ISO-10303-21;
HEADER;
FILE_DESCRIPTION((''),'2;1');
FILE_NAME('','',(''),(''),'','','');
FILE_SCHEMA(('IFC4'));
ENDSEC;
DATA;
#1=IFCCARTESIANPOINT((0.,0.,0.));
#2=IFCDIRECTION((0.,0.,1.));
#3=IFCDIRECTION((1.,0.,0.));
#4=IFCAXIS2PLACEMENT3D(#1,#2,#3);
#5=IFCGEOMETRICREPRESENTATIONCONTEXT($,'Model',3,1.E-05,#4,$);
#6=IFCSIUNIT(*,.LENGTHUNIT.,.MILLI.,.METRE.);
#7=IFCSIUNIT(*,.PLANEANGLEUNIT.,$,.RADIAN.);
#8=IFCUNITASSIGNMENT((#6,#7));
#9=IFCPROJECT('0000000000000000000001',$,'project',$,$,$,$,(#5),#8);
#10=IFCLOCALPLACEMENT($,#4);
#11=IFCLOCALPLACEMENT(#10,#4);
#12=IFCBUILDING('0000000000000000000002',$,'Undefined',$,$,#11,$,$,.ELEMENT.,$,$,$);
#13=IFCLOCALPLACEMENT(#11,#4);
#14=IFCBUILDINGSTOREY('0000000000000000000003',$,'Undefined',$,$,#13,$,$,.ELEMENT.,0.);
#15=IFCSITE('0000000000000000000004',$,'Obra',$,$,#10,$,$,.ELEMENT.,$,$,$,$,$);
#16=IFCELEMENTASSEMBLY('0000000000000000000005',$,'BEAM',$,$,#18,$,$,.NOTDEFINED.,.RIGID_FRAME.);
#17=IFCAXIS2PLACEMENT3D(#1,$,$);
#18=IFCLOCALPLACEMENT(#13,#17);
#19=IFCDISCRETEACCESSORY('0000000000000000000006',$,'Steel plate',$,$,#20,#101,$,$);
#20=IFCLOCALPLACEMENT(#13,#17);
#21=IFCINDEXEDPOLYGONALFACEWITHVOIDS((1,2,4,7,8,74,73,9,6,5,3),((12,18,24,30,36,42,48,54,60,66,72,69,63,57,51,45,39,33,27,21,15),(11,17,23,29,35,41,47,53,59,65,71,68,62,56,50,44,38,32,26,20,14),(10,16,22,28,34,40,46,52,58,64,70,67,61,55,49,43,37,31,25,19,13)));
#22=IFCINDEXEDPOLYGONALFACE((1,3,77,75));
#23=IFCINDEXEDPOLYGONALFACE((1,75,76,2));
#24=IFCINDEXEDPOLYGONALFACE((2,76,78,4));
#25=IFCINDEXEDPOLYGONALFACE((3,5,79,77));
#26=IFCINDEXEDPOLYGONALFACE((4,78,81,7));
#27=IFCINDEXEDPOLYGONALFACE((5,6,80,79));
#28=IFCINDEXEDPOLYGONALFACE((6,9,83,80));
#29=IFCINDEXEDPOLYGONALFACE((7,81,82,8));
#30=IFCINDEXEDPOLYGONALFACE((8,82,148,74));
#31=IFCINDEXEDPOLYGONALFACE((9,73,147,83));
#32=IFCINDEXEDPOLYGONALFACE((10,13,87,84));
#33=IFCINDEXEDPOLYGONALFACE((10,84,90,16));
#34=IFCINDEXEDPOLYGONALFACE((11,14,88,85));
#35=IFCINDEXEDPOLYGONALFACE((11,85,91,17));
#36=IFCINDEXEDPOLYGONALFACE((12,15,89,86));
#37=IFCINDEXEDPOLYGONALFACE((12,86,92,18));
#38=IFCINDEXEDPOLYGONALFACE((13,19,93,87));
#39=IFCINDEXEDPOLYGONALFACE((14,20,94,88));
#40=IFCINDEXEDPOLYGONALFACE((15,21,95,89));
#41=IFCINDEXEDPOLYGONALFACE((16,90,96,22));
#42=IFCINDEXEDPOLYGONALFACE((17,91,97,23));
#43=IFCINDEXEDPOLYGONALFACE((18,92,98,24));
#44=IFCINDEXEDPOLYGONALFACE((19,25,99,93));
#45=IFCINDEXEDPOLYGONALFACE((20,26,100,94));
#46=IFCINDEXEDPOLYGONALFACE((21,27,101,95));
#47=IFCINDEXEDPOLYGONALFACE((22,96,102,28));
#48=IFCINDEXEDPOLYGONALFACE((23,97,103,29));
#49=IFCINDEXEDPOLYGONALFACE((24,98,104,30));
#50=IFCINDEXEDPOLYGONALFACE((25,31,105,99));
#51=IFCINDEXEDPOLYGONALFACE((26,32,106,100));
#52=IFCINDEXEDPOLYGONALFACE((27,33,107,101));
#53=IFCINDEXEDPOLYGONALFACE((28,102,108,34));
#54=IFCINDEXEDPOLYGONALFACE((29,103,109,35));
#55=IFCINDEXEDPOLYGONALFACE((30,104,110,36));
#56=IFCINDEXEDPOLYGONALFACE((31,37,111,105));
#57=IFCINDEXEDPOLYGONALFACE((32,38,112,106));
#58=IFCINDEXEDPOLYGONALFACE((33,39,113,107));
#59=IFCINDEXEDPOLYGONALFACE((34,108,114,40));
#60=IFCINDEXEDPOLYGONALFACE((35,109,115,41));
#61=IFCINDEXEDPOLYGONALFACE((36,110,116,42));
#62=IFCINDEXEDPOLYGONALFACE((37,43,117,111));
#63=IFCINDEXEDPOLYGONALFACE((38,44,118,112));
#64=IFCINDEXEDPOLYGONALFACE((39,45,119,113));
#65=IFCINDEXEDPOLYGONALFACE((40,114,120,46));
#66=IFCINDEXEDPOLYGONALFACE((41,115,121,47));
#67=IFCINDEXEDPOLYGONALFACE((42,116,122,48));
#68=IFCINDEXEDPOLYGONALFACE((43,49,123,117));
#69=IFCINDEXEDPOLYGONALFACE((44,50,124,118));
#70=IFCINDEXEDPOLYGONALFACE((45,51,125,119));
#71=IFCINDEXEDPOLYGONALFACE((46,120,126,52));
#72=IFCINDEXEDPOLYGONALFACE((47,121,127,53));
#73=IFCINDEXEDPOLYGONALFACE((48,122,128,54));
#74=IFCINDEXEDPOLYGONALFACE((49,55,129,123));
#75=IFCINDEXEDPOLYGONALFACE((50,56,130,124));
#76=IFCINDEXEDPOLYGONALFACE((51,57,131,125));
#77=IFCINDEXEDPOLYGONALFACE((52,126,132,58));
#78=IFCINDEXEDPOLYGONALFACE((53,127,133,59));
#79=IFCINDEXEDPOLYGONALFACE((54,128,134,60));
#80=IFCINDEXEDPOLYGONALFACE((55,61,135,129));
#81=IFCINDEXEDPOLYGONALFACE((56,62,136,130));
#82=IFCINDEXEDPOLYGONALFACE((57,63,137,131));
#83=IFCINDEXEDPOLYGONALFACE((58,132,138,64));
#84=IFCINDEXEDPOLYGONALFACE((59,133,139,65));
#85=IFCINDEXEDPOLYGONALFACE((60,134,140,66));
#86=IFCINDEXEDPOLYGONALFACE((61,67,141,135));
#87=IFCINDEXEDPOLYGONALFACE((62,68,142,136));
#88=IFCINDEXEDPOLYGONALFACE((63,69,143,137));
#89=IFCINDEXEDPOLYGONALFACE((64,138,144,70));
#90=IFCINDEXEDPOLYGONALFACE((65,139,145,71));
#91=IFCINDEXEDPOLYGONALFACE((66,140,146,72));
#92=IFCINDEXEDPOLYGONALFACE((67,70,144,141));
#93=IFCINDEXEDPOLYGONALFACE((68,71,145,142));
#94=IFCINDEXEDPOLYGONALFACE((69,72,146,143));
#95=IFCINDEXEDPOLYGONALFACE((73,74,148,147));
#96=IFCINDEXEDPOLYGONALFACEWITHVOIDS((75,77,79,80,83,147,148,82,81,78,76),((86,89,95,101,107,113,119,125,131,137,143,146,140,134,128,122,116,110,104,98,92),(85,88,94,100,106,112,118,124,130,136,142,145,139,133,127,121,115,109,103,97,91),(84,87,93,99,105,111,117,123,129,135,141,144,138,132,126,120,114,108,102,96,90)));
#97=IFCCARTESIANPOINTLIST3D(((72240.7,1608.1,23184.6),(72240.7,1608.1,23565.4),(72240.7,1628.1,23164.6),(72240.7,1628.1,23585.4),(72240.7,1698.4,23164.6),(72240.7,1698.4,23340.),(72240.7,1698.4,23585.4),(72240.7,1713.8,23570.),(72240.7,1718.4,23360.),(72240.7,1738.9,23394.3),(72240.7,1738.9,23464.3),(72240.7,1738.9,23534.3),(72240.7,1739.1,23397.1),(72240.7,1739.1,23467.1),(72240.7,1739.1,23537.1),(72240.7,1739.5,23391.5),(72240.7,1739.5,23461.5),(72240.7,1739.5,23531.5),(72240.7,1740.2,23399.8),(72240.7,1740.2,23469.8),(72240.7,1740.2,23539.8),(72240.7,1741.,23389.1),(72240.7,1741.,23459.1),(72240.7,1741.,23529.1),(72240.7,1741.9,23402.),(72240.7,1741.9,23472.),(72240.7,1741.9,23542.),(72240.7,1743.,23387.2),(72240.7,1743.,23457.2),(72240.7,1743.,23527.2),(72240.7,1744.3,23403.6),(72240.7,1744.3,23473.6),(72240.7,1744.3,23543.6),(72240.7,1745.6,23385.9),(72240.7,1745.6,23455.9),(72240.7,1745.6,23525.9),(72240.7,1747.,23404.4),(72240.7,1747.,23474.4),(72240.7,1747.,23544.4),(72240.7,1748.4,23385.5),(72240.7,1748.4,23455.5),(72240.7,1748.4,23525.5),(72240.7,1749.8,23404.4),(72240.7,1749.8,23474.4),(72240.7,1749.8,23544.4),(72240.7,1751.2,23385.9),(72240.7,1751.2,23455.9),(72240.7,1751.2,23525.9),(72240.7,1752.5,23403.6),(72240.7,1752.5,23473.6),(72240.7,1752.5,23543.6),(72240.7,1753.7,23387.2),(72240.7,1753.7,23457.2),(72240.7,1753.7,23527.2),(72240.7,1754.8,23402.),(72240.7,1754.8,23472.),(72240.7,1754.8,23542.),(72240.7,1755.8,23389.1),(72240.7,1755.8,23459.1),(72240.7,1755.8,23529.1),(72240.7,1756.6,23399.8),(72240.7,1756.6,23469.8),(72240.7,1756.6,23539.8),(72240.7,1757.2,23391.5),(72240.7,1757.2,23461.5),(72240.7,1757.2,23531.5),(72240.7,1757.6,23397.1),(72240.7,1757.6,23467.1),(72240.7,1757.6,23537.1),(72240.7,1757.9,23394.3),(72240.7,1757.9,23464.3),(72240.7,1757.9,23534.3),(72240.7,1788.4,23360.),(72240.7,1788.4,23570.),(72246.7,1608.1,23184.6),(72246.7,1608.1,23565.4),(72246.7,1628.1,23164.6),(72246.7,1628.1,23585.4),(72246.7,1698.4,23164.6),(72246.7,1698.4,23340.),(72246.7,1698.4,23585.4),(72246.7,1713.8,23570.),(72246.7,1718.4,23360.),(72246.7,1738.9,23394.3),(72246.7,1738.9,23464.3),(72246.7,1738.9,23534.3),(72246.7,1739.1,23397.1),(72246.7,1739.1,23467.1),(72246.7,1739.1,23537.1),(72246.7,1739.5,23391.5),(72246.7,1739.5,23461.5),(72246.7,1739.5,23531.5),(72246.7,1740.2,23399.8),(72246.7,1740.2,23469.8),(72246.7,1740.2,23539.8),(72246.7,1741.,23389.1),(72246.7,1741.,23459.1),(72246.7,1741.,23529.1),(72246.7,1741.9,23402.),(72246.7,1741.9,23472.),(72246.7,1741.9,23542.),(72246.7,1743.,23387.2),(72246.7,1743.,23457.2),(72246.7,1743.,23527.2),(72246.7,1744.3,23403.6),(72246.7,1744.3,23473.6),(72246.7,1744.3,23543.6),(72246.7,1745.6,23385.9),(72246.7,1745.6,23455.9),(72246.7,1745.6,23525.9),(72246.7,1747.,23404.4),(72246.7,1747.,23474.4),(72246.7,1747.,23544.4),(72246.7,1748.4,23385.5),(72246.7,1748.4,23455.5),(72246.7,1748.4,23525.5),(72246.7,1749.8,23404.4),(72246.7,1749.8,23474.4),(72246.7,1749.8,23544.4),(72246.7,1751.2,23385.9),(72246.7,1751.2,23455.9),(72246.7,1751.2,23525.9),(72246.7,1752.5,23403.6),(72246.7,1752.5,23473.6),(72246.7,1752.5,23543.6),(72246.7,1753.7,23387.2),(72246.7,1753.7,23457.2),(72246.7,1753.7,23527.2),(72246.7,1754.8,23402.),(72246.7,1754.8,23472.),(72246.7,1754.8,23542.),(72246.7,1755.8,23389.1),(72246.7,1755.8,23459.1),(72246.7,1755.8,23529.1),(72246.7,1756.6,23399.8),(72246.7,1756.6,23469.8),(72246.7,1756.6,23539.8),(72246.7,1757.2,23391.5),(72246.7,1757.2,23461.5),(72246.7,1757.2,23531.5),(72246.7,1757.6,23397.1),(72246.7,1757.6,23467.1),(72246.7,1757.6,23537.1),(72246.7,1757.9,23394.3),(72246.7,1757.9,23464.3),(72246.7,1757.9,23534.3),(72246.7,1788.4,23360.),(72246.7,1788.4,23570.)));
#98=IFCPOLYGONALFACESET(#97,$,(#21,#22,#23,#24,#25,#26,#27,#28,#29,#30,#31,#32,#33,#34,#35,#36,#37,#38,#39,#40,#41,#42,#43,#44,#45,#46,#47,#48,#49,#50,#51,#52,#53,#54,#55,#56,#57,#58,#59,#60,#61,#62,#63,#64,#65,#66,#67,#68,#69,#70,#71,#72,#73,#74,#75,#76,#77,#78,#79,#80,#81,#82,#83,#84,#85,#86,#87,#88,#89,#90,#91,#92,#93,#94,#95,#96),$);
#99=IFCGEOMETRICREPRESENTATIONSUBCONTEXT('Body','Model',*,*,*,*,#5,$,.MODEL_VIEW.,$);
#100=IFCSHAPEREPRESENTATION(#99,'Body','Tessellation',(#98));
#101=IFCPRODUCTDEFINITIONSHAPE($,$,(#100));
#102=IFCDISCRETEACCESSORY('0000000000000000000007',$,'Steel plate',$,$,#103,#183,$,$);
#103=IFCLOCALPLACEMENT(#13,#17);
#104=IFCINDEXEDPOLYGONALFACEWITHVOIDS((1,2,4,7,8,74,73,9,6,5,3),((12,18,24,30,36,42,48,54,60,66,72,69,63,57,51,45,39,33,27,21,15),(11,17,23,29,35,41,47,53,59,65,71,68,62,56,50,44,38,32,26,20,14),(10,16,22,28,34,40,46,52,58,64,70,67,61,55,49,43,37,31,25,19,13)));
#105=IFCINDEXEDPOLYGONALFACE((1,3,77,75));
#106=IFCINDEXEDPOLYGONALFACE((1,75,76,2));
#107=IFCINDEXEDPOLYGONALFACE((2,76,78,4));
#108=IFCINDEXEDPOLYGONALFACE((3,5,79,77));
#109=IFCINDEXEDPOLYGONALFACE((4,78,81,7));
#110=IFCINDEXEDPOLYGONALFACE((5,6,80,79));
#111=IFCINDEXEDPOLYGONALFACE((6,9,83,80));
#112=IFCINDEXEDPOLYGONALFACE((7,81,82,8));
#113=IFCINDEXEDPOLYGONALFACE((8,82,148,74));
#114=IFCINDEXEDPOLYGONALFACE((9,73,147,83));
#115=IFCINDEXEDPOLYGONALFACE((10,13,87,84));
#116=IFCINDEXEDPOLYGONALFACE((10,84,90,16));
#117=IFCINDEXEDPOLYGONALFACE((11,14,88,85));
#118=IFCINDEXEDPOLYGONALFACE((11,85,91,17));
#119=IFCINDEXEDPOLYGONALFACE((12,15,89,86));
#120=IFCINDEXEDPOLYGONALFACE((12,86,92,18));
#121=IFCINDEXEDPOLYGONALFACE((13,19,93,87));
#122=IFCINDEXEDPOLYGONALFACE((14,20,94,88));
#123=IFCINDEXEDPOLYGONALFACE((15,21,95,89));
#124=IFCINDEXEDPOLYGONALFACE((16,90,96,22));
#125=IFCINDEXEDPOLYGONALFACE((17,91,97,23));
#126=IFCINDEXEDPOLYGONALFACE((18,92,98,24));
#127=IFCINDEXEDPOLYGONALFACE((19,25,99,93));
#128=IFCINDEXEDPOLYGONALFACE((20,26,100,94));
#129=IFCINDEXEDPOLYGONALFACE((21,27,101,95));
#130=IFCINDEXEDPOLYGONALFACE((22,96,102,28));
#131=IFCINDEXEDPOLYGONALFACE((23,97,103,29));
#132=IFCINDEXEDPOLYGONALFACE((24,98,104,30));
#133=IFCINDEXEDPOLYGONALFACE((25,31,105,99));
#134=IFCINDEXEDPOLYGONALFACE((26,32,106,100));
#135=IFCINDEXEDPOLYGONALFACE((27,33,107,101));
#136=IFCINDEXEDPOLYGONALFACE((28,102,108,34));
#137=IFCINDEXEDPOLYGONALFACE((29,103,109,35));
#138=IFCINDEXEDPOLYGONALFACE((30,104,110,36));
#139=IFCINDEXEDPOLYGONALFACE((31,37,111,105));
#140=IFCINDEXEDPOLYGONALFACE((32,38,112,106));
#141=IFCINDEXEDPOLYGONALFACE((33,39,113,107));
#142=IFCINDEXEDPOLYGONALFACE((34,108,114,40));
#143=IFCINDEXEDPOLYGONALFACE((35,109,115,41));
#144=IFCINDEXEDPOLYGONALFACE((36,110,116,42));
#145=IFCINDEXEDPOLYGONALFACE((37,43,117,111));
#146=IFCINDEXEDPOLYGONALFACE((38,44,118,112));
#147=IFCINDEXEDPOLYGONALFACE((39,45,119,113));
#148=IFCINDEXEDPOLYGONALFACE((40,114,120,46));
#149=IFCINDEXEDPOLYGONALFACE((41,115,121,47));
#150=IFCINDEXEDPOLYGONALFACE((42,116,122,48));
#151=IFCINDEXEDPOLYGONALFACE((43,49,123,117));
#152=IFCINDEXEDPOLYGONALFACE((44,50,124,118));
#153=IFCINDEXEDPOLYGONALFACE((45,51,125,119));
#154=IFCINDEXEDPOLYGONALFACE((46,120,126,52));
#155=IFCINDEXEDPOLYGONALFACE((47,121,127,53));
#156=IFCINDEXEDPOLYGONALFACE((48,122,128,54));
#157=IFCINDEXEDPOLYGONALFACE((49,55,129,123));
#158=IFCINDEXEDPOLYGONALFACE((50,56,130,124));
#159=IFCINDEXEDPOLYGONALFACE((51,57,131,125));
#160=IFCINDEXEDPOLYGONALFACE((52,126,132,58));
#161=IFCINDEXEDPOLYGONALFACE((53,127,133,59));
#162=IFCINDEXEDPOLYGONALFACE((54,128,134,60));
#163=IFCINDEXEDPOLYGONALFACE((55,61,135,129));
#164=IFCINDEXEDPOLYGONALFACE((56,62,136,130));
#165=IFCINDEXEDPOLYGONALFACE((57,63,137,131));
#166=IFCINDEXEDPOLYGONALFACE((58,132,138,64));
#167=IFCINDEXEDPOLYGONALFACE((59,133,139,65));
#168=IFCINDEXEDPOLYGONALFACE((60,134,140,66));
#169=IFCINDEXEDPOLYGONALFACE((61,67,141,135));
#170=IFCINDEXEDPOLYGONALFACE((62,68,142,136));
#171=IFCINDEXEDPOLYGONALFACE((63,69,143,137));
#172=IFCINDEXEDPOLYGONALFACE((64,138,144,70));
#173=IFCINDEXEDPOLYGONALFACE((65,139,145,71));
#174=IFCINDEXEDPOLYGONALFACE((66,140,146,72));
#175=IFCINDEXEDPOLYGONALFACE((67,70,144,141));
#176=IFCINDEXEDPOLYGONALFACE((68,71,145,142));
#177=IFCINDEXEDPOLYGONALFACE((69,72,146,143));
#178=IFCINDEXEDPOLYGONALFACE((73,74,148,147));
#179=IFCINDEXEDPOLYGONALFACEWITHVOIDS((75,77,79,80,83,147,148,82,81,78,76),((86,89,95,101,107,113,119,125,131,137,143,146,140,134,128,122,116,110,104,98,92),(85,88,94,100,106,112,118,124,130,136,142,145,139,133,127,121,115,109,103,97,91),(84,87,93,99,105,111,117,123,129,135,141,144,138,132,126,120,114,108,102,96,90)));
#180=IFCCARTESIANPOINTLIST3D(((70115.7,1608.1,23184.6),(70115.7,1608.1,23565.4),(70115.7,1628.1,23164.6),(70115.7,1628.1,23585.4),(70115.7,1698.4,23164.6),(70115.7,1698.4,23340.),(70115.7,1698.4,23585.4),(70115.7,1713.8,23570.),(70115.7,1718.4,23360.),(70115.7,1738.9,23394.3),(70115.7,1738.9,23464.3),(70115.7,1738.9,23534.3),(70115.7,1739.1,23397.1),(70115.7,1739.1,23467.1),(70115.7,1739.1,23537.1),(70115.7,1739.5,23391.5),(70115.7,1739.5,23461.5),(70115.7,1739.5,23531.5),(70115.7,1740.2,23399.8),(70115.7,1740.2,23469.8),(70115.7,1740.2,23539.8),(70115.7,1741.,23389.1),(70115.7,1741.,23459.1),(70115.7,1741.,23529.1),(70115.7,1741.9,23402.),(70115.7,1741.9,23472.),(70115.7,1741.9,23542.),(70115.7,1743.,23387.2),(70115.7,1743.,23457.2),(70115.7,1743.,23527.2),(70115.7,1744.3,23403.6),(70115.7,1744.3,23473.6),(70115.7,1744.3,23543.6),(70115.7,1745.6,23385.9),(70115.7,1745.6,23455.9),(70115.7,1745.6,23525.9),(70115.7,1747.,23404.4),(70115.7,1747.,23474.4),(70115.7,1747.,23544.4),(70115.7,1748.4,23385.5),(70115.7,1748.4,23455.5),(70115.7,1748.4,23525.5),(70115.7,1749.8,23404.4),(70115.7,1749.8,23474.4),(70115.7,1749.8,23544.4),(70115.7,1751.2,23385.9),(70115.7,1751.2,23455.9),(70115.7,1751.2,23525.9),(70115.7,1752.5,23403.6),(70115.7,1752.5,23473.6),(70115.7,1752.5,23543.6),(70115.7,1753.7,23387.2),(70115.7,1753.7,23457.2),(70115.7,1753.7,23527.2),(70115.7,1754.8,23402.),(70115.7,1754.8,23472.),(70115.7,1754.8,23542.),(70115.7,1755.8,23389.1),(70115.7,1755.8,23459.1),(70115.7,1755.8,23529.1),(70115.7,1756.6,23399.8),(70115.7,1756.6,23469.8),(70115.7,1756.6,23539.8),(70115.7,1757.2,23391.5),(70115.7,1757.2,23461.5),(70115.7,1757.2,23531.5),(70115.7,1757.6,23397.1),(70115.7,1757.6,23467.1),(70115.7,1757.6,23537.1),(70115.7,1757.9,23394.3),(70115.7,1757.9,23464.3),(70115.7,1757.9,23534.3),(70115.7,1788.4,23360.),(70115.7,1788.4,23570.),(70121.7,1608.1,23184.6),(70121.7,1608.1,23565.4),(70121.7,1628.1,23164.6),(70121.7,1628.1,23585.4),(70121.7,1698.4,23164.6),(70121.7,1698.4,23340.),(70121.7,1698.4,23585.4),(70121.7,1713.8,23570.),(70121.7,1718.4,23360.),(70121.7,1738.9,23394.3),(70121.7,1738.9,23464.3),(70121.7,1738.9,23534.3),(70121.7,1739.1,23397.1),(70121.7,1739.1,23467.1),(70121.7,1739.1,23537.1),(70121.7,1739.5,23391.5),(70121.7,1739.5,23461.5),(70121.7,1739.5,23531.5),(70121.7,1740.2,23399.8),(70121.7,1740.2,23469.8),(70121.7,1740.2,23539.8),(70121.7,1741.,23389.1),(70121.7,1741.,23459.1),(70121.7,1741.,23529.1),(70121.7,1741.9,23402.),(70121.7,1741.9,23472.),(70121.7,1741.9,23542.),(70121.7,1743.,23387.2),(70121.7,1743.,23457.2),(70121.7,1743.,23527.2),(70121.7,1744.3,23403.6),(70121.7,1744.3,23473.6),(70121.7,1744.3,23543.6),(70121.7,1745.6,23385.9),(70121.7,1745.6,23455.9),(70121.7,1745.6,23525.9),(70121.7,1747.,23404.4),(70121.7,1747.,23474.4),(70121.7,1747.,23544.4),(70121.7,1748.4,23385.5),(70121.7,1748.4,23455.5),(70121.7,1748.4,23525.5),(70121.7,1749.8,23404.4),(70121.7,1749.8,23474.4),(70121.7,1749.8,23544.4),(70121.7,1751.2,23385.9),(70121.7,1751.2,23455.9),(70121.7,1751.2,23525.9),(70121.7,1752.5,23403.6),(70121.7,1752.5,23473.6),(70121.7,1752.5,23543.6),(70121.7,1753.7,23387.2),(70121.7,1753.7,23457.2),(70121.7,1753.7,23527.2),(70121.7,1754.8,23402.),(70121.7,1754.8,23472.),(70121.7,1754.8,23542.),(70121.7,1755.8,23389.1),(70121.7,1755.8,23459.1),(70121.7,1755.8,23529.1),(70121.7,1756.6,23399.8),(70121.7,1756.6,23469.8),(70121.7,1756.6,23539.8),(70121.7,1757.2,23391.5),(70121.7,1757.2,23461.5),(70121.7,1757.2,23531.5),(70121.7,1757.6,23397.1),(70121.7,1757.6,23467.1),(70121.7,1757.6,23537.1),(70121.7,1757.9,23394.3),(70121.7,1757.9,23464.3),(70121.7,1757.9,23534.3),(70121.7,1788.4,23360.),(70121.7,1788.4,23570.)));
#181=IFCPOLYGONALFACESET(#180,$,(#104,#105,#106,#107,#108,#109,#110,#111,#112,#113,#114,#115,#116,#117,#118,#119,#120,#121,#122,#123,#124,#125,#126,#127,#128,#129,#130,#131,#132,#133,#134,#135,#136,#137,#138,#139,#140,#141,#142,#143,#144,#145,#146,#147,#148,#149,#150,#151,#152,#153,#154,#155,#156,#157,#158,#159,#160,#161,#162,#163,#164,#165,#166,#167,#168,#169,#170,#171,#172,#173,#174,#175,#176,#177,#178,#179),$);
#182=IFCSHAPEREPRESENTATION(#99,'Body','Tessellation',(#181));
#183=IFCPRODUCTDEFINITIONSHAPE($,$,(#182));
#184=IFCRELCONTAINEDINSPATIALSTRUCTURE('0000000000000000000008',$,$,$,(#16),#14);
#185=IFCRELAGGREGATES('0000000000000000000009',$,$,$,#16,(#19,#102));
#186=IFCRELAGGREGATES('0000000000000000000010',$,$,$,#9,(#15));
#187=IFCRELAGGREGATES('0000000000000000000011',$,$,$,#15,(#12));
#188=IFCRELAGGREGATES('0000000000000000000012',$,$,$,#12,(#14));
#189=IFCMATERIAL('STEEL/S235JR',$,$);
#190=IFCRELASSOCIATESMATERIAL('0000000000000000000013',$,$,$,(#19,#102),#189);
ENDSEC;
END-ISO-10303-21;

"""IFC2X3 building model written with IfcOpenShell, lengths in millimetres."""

from ifc_helpers import new_model, si_unit, frame, origin_with_axes, origin_2d_with_axis, place, context, subcontext, project, spatial, polyline, circle, outline, extrude, source, transform, mapped, material, element, aggregate, save


model = new_model("IFC2X3")

# Units and contexts
model_context = context("Model", 3, precision=1e-05, world=origin_with_axes())
body_context = subcontext(model_context, "Body", "Model", "MODEL_VIEW")
ifc_project = project(units=[si_unit("LENGTHUNIT", "METRE", prefix="MILLI"), si_unit("PLANEANGLEUNIT", "RADIAN")], contexts=[model_context])

# Site, building, storey
site_placement = place(None, origin_with_axes())
site = spatial("IfcSite", under=ifc_project, at=site_placement, Name="Obra", CompositionType="ELEMENT")
building_placement = place(site_placement, origin_with_axes())
building = spatial("IfcBuilding", under=site, at=building_placement, Name="Undefined", CompositionType="ELEMENT")
storey_placement = place(building_placement, origin_with_axes())
storey = spatial("IfcBuildingStorey", under=building, at=storey_placement, Name="Undefined", CompositionType="ELEMENT", Elevation=0.0)

# Element assembly
ifc_material_1 = material(Name="STEEL/S235JR")
assembly_1_placement = place(storey_placement, origin_with_axes())
assembly_1 = element("IfcElementAssembly", 1, at=assembly_1_placement, inside=storey, Name="BEAM", AssemblyPlace="NOTDEFINED", PredefinedType="RIGID_FRAME")

# Discrete accessories, openings
discrete_accessory_1_placement = place(assembly_1_placement, frame((72243.7, 1608.1, 23184.6), z_axis=(1.0, 0.0, 0.0), x_axis=(0.0, 0.707107, -0.707107)))
discrete_accessory_1 = element("IfcDiscreteAccessory", 2, at=discrete_accessory_1_placement, material=ifc_material_1, Name="Steel plate", context=body_context, shape_type="SweptSolid", body=[
    extrude(outline(polyline([(0.0, 0.0), (28.3, 0.0), (78.0, 49.7), (-46.0, 173.7), (-46.0, 202.0), (3.5, 251.5), (-145.0, 400.0), (-197.8, 347.3), (-219.6, 347.3), (-219.6, 347.3), (-269.3, 297.6), (-269.3, 269.3), (0.0, 0.0)])), frame((0.0, 0.0, -3.0), z_axis=(0.0, 0.0, 1.0), x_axis=(1.0, 0.0, 0.0)), (0.0, 0.0, 1.0), 6.0),
])
shared_shape_1 = source(origin_with_axes(), body_context, "Body", "SweptSolid", [
    extrude(circle(Radius=9.5, at=origin_2d_with_axis()), frame((0.0, 3.2, 0.0), z_axis=(0.0, 1.0, 0.0), x_axis=(1.0, 0.0, 0.0)), (0.0, 0.0, 1.0), 6.2),
])
opening_1_placement = place(assembly_1_placement, frame((72250.0, 1708.4, 23570.0), z_axis=(0.0, 1.0, 0.0), x_axis=(0.0, 0.0, -1.0)))
element("IfcOpeningElement", 3, at=opening_1_placement, cuts=discrete_accessory_1, ObjectType="Opening", context=body_context, shape_type="MappedRepresentation", body=[
    mapped(shared_shape_1, transform((35.0, 0.0, 40.0))),
    mapped(shared_shape_1, transform((105.0, 0.0, 40.0))),
    mapped(shared_shape_1, transform((175.0, 0.0, 40.0))),
])
discrete_accessory_2_placement = place(assembly_1_placement, frame((70118.7, 1608.1, 23184.6), z_axis=(1.0, 0.0, 0.0), x_axis=(0.0, 0.707107, -0.707107)))
discrete_accessory_2 = element("IfcDiscreteAccessory", 4, at=discrete_accessory_2_placement, material=ifc_material_1, Name="Steel plate", context=body_context, shape_type="SweptSolid", body=[
    extrude(outline(polyline([(0.0, 0.0), (28.3, 0.0), (78.0, 49.7), (-46.0, 173.7), (-46.0, 202.0), (3.5, 251.5), (-145.0, 400.0), (-197.8, 347.3), (-219.6, 347.3), (-219.6, 347.3), (-269.3, 297.6), (-269.3, 269.3), (0.0, 0.0)])), frame((0.0, 0.0, -3.0), z_axis=(0.0, 0.0, 1.0), x_axis=(1.0, 0.0, 0.0)), (0.0, 0.0, 1.0), 6.0),
])
opening_2_placement = place(assembly_1_placement, frame((70125.0, 1708.4, 23570.0), z_axis=(0.0, 1.0, 0.0), x_axis=(0.0, 0.0, -1.0)))
element("IfcOpeningElement", 5, at=opening_2_placement, cuts=discrete_accessory_2, ObjectType="Opening", context=body_context, shape_type="MappedRepresentation", body=[
    mapped(shared_shape_1, transform((35.0, 0.0, 40.0))),
    mapped(shared_shape_1, transform((105.0, 0.0, 40.0))),
    mapped(shared_shape_1, transform((175.0, 0.0, 40.0))),
])
aggregate(assembly_1, [discrete_accessory_1, discrete_accessory_2])

save(model, "model.ifc")
